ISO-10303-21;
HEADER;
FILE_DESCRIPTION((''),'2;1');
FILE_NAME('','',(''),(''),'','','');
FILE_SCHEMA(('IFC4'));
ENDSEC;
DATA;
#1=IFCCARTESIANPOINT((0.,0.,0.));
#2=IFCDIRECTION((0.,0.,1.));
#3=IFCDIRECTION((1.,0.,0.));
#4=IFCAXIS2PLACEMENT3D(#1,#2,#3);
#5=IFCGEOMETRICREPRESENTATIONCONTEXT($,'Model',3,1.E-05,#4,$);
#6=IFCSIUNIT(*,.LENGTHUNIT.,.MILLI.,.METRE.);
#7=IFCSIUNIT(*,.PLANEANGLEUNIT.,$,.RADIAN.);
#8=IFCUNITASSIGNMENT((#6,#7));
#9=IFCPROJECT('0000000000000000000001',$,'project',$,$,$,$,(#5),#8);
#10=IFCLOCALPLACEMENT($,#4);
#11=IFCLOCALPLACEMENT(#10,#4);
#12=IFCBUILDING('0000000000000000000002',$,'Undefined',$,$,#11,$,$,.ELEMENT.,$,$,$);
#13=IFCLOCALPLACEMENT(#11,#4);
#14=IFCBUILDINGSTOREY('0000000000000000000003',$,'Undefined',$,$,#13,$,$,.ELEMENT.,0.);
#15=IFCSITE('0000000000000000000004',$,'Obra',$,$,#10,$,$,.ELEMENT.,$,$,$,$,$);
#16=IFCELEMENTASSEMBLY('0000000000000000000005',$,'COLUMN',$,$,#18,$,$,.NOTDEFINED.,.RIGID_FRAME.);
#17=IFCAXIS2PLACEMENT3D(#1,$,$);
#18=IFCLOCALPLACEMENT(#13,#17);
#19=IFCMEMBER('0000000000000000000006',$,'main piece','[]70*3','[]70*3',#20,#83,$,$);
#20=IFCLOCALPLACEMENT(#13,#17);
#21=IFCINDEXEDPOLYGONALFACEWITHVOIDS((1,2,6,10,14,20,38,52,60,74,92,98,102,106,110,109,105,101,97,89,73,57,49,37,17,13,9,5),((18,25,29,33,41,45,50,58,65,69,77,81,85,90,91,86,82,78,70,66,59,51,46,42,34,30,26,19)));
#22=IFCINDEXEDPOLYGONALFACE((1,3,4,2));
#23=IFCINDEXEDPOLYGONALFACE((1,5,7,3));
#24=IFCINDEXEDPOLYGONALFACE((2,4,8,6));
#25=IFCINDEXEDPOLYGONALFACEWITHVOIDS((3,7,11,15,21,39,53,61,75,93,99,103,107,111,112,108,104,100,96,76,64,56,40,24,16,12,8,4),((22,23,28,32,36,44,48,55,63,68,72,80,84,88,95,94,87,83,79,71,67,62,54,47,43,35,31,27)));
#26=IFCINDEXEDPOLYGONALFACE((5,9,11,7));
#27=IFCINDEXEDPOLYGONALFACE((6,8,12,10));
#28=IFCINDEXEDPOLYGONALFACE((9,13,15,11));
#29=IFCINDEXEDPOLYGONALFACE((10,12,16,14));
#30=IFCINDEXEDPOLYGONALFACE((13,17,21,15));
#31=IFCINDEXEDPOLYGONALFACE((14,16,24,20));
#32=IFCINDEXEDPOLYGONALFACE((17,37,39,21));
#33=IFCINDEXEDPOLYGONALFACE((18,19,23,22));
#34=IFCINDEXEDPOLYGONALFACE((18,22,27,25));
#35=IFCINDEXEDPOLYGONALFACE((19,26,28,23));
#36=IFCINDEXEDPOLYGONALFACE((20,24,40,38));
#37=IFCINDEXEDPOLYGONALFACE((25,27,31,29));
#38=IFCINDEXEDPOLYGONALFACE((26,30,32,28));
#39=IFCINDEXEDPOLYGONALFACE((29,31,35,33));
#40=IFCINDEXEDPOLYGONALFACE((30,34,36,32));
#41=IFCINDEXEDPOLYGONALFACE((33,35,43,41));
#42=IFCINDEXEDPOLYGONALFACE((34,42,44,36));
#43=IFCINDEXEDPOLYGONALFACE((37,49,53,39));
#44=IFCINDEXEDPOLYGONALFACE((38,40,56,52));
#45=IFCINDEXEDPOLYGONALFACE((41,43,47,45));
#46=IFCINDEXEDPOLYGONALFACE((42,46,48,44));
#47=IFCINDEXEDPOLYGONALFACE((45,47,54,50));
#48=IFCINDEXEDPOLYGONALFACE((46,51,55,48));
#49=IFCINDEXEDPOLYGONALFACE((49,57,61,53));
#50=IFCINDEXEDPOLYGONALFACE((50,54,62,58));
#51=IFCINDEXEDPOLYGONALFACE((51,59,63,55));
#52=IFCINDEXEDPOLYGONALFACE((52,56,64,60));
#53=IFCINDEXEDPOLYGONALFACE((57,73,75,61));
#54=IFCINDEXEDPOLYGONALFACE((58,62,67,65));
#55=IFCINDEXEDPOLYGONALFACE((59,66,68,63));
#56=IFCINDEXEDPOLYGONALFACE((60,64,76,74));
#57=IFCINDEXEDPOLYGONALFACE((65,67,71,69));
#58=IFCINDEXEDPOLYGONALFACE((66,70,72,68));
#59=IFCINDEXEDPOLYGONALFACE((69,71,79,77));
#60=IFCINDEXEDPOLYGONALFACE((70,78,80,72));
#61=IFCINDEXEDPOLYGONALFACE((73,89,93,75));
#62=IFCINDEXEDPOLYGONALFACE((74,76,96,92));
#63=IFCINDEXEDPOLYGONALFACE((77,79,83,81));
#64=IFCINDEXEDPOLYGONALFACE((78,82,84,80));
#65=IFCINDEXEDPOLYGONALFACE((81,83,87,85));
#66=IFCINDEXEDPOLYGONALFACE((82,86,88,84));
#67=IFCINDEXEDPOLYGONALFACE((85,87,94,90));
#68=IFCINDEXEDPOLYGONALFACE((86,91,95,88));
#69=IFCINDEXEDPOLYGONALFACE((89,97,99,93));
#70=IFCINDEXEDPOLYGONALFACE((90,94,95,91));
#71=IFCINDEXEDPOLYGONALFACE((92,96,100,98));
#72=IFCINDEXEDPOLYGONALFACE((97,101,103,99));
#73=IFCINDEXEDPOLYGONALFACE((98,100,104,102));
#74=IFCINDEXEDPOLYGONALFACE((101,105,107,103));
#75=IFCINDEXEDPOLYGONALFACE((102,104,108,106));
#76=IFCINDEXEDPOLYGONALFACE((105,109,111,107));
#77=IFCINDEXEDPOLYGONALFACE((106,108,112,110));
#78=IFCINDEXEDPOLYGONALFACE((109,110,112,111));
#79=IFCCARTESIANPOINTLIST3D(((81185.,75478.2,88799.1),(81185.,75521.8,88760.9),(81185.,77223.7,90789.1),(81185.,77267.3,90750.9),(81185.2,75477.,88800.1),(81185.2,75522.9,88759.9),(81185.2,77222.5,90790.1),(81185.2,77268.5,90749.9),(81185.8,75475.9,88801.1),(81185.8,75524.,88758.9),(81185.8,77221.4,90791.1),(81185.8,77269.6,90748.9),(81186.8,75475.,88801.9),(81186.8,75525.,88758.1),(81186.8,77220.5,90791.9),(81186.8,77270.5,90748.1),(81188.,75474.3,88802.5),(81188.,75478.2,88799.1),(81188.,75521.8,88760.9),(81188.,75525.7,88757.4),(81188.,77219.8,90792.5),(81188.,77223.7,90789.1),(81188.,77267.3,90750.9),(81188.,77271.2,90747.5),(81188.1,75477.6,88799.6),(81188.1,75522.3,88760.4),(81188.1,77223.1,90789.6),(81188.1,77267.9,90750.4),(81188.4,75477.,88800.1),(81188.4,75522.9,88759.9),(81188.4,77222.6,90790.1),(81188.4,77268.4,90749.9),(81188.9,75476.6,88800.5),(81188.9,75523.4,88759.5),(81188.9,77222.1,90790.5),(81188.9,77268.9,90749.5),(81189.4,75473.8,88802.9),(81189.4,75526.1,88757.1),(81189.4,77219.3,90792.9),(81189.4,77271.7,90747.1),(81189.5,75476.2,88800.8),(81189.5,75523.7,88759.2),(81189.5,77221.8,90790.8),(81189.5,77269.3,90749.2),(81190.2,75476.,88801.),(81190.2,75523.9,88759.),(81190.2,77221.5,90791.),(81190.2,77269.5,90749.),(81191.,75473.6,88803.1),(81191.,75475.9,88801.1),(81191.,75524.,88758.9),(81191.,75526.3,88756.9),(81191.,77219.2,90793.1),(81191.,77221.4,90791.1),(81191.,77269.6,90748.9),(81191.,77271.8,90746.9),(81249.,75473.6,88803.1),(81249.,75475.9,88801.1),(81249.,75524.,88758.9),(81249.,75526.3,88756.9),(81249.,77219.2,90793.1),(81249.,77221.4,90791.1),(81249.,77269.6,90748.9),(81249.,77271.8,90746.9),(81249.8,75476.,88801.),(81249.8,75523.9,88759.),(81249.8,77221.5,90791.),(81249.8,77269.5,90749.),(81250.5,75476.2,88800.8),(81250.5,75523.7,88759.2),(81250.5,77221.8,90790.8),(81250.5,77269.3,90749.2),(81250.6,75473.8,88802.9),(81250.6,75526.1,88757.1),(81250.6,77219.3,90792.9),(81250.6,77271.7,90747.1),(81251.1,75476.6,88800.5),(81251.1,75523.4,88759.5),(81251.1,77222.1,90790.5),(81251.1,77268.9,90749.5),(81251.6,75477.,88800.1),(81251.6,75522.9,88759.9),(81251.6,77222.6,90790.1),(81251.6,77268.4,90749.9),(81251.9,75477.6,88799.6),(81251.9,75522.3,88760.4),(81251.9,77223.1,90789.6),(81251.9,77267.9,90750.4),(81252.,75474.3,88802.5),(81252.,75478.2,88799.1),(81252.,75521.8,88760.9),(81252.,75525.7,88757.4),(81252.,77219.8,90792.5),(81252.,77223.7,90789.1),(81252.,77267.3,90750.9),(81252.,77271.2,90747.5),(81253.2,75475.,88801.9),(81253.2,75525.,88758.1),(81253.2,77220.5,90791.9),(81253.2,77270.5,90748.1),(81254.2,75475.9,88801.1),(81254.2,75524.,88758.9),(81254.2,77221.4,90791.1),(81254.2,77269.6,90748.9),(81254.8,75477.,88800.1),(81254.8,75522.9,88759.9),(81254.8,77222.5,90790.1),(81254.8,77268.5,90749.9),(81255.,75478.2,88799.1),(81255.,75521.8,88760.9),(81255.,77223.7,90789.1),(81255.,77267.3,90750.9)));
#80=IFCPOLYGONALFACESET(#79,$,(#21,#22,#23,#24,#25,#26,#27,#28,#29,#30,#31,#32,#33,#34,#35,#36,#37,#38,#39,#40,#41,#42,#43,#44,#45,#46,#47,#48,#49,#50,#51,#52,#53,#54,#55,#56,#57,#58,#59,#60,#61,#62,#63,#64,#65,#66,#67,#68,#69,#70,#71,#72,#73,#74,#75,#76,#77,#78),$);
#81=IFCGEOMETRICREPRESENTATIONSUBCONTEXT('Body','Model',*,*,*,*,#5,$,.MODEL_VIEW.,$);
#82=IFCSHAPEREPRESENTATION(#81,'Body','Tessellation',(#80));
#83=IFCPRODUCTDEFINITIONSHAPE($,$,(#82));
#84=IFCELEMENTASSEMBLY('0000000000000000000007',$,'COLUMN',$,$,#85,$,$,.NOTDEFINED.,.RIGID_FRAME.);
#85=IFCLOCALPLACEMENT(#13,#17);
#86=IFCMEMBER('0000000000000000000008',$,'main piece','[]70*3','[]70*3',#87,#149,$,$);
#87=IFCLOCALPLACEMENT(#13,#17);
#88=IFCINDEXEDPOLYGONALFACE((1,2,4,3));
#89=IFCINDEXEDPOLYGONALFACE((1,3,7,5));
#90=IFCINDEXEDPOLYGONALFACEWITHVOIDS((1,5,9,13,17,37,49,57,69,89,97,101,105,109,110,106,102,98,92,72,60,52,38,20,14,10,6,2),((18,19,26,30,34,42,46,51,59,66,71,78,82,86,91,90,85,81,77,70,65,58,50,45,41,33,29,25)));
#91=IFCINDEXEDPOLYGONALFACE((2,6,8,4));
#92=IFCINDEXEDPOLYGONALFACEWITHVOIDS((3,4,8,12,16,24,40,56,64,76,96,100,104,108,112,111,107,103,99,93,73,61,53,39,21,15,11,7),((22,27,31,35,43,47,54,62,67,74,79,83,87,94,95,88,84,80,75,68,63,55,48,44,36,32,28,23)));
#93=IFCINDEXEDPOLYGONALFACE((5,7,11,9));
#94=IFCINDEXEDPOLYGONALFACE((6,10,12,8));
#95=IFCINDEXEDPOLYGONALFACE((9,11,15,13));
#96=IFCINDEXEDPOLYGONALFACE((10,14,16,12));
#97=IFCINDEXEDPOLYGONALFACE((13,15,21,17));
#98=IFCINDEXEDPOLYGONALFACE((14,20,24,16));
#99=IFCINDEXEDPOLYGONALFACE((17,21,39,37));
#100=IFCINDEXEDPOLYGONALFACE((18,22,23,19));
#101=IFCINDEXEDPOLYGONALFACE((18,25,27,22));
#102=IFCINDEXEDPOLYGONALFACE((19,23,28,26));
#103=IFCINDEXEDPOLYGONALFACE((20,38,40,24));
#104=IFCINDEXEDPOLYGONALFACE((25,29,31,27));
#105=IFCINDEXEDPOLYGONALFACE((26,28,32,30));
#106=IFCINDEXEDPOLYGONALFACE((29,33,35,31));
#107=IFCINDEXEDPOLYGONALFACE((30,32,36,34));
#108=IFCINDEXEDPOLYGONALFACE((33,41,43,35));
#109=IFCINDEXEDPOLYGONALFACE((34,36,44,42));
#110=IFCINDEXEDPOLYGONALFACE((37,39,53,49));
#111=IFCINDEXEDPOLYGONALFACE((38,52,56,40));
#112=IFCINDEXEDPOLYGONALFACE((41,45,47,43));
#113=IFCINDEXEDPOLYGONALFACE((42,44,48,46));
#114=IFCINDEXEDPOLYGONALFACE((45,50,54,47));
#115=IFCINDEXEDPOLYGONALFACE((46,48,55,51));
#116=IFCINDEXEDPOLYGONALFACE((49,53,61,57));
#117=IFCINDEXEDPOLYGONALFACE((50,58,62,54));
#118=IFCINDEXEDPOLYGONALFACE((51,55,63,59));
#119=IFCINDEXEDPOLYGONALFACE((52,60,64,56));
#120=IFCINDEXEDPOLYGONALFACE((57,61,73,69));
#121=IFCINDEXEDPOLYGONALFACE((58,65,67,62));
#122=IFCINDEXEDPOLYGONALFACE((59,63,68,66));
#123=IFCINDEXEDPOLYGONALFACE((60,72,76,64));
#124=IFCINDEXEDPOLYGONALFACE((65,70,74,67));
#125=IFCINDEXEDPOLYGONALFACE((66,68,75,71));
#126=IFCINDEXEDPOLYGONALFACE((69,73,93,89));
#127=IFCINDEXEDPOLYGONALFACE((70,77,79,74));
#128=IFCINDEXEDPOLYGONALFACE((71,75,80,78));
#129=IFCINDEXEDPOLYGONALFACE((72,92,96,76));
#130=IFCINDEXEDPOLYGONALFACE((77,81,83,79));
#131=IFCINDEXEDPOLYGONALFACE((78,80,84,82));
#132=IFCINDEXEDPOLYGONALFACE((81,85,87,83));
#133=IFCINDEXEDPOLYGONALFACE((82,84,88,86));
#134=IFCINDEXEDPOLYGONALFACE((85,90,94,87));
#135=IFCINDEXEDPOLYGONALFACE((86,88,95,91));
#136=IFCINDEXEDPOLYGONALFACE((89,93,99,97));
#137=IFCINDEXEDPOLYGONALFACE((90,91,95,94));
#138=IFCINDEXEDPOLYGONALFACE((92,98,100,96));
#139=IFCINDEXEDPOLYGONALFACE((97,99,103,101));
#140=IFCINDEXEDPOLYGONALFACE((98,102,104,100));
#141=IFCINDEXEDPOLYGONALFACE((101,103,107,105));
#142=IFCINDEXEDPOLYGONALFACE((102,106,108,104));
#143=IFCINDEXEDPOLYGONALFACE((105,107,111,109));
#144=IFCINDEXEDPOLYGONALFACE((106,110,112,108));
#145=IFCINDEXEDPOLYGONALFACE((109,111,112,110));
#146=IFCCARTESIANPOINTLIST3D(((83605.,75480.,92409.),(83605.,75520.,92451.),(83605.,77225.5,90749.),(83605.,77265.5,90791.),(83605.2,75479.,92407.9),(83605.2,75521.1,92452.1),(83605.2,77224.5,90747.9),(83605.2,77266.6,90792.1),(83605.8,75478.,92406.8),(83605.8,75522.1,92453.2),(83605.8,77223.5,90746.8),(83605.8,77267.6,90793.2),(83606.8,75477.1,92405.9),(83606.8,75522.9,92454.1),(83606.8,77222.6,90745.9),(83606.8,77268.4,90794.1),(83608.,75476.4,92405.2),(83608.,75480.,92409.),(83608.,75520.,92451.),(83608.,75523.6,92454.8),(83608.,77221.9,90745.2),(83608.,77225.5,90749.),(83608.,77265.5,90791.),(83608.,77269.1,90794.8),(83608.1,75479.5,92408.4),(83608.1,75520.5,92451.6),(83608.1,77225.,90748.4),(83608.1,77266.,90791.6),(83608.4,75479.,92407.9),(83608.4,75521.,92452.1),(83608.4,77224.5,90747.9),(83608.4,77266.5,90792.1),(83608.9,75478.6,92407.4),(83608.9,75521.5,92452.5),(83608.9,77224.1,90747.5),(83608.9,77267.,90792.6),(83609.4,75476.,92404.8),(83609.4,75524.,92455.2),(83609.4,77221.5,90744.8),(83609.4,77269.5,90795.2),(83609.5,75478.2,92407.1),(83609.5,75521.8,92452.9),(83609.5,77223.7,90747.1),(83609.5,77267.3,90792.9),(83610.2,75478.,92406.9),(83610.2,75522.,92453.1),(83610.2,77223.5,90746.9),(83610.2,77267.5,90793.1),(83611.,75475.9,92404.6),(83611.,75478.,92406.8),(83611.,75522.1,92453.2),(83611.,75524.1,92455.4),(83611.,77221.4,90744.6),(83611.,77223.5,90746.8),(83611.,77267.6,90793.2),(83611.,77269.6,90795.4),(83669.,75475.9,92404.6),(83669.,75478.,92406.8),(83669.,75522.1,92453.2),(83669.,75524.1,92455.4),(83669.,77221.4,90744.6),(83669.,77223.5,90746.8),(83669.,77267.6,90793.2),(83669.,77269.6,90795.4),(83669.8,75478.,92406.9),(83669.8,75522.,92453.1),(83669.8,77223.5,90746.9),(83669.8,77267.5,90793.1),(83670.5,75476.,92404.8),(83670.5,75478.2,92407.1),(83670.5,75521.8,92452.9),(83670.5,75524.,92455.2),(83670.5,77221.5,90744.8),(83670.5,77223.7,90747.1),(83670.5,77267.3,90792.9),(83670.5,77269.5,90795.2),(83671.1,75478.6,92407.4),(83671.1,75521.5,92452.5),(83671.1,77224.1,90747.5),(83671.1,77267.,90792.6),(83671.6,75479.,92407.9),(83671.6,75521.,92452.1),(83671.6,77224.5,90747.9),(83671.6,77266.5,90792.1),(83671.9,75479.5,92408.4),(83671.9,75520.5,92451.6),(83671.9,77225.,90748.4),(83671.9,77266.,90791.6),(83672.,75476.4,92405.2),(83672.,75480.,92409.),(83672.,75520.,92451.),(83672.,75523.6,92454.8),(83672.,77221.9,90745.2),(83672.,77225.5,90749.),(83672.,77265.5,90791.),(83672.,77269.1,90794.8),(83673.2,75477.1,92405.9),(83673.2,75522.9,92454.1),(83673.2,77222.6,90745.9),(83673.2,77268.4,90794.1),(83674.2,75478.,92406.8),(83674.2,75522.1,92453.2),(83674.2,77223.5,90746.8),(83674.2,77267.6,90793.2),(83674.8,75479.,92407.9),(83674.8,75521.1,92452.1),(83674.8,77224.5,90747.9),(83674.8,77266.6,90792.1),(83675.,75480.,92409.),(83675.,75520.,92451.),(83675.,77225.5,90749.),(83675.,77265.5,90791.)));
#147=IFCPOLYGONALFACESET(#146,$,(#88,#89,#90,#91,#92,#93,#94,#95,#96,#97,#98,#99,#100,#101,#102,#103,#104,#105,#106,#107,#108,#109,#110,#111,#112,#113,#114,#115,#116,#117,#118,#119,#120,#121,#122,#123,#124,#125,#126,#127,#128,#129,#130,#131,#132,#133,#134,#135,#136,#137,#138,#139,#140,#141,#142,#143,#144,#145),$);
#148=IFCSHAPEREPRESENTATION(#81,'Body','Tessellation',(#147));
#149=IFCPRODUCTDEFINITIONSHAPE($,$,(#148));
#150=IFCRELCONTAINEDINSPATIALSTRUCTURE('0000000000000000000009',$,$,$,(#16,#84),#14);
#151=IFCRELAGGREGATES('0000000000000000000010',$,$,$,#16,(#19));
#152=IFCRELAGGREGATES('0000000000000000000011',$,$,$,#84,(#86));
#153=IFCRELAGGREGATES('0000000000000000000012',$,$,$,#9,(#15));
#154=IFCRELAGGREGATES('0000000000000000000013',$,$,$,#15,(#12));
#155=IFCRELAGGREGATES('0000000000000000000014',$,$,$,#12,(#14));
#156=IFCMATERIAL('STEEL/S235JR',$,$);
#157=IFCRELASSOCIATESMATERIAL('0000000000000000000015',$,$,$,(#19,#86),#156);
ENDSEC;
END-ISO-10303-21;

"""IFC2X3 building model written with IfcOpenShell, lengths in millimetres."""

from ifc_helpers import new_model, si_unit, frame, origin_with_axes, origin_2d_with_axis, place, context, subcontext, project, spatial, hollow_rectangle, extrude, material, element, aggregate, save


model = new_model("IFC2X3")

# Units and contexts
model_context = context("Model", 3, precision=1e-05, world=origin_with_axes())
body_context = subcontext(model_context, "Body", "Model", "MODEL_VIEW")
ifc_project = project(units=[si_unit("LENGTHUNIT", "METRE", prefix="MILLI"), si_unit("PLANEANGLEUNIT", "RADIAN")], contexts=[model_context])

# Site, building, storey
site_placement = place(None, origin_with_axes())
site = spatial("IfcSite", under=ifc_project, at=site_placement, Name="Obra", CompositionType="ELEMENT")
building_placement = place(site_placement, origin_with_axes())
building = spatial("IfcBuilding", under=site, at=building_placement, Name="Undefined", CompositionType="ELEMENT")
storey_placement = place(building_placement, origin_with_axes())
storey = spatial("IfcBuildingStorey", under=building, at=storey_placement, Name="Undefined", CompositionType="ELEMENT", Elevation=0.0)

# Shared definitions
ifc_material = material(Name="STEEL/S235JR")

# Element assemblies, members
assembly_1_placement = place(storey_placement, origin_with_axes())
assembly_1 = element("IfcElementAssembly", 1, at=assembly_1_placement, inside=storey, Name="COLUMN", AssemblyPlace="NOTDEFINED", PredefinedType="RIGID_FRAME")
member_1_placement = place(assembly_1_placement, frame((81220.0, 75500.0, 88780.0), z_axis=(-1.0, 0.0, 0.0), x_axis=(0.0, 0.659423, 0.751772)))
member_1 = element("IfcMember", 2, at=member_1_placement, material=ifc_material, Name="main piece", Description="[]70*3", ObjectType="[]70*3", context=body_context, shape_type="SweptSolid", body=[
    extrude(hollow_rectangle(XDim=70.0, YDim=70.0, WallThickness=3.0, InnerFilletRadius=3.0, OuterFilletRadius=6.0, at=origin_2d_with_axis()), frame((2647.1, 0.0, 0.0), z_axis=(-1.0, 0.0, 0.0), x_axis=(0.0, -1.0, 0.0)), (0.0, 0.0, 1.0), 2647.1),
])
aggregate(assembly_1, [member_1])
assembly_2_placement = place(storey_placement, origin_with_axes())
assembly_2 = element("IfcElementAssembly", 3, at=assembly_2_placement, inside=storey, Name="COLUMN", AssemblyPlace="NOTDEFINED", PredefinedType="RIGID_FRAME")
member_2_placement = place(assembly_2_placement, frame((83640.0, 77245.5, 90770.0), z_axis=(1.0, 0.0, 0.0), x_axis=(0.0, -0.724633, 0.689135)))
member_2 = element("IfcMember", 4, at=member_2_placement, material=ifc_material, Name="main piece", Description="[]70*3", ObjectType="[]70*3", context=body_context, shape_type="SweptSolid", body=[
    extrude(hollow_rectangle(XDim=70.0, YDim=70.0, WallThickness=3.0, InnerFilletRadius=3.0, OuterFilletRadius=6.0, at=origin_2d_with_axis()), frame((2408.8, 0.0, 0.0), z_axis=(-1.0, 0.0, 0.0), x_axis=(0.0, -1.0, 0.0)), (0.0, 0.0, 1.0), 2408.8),
])
aggregate(assembly_2, [member_2])

save(model, "model.ifc")
